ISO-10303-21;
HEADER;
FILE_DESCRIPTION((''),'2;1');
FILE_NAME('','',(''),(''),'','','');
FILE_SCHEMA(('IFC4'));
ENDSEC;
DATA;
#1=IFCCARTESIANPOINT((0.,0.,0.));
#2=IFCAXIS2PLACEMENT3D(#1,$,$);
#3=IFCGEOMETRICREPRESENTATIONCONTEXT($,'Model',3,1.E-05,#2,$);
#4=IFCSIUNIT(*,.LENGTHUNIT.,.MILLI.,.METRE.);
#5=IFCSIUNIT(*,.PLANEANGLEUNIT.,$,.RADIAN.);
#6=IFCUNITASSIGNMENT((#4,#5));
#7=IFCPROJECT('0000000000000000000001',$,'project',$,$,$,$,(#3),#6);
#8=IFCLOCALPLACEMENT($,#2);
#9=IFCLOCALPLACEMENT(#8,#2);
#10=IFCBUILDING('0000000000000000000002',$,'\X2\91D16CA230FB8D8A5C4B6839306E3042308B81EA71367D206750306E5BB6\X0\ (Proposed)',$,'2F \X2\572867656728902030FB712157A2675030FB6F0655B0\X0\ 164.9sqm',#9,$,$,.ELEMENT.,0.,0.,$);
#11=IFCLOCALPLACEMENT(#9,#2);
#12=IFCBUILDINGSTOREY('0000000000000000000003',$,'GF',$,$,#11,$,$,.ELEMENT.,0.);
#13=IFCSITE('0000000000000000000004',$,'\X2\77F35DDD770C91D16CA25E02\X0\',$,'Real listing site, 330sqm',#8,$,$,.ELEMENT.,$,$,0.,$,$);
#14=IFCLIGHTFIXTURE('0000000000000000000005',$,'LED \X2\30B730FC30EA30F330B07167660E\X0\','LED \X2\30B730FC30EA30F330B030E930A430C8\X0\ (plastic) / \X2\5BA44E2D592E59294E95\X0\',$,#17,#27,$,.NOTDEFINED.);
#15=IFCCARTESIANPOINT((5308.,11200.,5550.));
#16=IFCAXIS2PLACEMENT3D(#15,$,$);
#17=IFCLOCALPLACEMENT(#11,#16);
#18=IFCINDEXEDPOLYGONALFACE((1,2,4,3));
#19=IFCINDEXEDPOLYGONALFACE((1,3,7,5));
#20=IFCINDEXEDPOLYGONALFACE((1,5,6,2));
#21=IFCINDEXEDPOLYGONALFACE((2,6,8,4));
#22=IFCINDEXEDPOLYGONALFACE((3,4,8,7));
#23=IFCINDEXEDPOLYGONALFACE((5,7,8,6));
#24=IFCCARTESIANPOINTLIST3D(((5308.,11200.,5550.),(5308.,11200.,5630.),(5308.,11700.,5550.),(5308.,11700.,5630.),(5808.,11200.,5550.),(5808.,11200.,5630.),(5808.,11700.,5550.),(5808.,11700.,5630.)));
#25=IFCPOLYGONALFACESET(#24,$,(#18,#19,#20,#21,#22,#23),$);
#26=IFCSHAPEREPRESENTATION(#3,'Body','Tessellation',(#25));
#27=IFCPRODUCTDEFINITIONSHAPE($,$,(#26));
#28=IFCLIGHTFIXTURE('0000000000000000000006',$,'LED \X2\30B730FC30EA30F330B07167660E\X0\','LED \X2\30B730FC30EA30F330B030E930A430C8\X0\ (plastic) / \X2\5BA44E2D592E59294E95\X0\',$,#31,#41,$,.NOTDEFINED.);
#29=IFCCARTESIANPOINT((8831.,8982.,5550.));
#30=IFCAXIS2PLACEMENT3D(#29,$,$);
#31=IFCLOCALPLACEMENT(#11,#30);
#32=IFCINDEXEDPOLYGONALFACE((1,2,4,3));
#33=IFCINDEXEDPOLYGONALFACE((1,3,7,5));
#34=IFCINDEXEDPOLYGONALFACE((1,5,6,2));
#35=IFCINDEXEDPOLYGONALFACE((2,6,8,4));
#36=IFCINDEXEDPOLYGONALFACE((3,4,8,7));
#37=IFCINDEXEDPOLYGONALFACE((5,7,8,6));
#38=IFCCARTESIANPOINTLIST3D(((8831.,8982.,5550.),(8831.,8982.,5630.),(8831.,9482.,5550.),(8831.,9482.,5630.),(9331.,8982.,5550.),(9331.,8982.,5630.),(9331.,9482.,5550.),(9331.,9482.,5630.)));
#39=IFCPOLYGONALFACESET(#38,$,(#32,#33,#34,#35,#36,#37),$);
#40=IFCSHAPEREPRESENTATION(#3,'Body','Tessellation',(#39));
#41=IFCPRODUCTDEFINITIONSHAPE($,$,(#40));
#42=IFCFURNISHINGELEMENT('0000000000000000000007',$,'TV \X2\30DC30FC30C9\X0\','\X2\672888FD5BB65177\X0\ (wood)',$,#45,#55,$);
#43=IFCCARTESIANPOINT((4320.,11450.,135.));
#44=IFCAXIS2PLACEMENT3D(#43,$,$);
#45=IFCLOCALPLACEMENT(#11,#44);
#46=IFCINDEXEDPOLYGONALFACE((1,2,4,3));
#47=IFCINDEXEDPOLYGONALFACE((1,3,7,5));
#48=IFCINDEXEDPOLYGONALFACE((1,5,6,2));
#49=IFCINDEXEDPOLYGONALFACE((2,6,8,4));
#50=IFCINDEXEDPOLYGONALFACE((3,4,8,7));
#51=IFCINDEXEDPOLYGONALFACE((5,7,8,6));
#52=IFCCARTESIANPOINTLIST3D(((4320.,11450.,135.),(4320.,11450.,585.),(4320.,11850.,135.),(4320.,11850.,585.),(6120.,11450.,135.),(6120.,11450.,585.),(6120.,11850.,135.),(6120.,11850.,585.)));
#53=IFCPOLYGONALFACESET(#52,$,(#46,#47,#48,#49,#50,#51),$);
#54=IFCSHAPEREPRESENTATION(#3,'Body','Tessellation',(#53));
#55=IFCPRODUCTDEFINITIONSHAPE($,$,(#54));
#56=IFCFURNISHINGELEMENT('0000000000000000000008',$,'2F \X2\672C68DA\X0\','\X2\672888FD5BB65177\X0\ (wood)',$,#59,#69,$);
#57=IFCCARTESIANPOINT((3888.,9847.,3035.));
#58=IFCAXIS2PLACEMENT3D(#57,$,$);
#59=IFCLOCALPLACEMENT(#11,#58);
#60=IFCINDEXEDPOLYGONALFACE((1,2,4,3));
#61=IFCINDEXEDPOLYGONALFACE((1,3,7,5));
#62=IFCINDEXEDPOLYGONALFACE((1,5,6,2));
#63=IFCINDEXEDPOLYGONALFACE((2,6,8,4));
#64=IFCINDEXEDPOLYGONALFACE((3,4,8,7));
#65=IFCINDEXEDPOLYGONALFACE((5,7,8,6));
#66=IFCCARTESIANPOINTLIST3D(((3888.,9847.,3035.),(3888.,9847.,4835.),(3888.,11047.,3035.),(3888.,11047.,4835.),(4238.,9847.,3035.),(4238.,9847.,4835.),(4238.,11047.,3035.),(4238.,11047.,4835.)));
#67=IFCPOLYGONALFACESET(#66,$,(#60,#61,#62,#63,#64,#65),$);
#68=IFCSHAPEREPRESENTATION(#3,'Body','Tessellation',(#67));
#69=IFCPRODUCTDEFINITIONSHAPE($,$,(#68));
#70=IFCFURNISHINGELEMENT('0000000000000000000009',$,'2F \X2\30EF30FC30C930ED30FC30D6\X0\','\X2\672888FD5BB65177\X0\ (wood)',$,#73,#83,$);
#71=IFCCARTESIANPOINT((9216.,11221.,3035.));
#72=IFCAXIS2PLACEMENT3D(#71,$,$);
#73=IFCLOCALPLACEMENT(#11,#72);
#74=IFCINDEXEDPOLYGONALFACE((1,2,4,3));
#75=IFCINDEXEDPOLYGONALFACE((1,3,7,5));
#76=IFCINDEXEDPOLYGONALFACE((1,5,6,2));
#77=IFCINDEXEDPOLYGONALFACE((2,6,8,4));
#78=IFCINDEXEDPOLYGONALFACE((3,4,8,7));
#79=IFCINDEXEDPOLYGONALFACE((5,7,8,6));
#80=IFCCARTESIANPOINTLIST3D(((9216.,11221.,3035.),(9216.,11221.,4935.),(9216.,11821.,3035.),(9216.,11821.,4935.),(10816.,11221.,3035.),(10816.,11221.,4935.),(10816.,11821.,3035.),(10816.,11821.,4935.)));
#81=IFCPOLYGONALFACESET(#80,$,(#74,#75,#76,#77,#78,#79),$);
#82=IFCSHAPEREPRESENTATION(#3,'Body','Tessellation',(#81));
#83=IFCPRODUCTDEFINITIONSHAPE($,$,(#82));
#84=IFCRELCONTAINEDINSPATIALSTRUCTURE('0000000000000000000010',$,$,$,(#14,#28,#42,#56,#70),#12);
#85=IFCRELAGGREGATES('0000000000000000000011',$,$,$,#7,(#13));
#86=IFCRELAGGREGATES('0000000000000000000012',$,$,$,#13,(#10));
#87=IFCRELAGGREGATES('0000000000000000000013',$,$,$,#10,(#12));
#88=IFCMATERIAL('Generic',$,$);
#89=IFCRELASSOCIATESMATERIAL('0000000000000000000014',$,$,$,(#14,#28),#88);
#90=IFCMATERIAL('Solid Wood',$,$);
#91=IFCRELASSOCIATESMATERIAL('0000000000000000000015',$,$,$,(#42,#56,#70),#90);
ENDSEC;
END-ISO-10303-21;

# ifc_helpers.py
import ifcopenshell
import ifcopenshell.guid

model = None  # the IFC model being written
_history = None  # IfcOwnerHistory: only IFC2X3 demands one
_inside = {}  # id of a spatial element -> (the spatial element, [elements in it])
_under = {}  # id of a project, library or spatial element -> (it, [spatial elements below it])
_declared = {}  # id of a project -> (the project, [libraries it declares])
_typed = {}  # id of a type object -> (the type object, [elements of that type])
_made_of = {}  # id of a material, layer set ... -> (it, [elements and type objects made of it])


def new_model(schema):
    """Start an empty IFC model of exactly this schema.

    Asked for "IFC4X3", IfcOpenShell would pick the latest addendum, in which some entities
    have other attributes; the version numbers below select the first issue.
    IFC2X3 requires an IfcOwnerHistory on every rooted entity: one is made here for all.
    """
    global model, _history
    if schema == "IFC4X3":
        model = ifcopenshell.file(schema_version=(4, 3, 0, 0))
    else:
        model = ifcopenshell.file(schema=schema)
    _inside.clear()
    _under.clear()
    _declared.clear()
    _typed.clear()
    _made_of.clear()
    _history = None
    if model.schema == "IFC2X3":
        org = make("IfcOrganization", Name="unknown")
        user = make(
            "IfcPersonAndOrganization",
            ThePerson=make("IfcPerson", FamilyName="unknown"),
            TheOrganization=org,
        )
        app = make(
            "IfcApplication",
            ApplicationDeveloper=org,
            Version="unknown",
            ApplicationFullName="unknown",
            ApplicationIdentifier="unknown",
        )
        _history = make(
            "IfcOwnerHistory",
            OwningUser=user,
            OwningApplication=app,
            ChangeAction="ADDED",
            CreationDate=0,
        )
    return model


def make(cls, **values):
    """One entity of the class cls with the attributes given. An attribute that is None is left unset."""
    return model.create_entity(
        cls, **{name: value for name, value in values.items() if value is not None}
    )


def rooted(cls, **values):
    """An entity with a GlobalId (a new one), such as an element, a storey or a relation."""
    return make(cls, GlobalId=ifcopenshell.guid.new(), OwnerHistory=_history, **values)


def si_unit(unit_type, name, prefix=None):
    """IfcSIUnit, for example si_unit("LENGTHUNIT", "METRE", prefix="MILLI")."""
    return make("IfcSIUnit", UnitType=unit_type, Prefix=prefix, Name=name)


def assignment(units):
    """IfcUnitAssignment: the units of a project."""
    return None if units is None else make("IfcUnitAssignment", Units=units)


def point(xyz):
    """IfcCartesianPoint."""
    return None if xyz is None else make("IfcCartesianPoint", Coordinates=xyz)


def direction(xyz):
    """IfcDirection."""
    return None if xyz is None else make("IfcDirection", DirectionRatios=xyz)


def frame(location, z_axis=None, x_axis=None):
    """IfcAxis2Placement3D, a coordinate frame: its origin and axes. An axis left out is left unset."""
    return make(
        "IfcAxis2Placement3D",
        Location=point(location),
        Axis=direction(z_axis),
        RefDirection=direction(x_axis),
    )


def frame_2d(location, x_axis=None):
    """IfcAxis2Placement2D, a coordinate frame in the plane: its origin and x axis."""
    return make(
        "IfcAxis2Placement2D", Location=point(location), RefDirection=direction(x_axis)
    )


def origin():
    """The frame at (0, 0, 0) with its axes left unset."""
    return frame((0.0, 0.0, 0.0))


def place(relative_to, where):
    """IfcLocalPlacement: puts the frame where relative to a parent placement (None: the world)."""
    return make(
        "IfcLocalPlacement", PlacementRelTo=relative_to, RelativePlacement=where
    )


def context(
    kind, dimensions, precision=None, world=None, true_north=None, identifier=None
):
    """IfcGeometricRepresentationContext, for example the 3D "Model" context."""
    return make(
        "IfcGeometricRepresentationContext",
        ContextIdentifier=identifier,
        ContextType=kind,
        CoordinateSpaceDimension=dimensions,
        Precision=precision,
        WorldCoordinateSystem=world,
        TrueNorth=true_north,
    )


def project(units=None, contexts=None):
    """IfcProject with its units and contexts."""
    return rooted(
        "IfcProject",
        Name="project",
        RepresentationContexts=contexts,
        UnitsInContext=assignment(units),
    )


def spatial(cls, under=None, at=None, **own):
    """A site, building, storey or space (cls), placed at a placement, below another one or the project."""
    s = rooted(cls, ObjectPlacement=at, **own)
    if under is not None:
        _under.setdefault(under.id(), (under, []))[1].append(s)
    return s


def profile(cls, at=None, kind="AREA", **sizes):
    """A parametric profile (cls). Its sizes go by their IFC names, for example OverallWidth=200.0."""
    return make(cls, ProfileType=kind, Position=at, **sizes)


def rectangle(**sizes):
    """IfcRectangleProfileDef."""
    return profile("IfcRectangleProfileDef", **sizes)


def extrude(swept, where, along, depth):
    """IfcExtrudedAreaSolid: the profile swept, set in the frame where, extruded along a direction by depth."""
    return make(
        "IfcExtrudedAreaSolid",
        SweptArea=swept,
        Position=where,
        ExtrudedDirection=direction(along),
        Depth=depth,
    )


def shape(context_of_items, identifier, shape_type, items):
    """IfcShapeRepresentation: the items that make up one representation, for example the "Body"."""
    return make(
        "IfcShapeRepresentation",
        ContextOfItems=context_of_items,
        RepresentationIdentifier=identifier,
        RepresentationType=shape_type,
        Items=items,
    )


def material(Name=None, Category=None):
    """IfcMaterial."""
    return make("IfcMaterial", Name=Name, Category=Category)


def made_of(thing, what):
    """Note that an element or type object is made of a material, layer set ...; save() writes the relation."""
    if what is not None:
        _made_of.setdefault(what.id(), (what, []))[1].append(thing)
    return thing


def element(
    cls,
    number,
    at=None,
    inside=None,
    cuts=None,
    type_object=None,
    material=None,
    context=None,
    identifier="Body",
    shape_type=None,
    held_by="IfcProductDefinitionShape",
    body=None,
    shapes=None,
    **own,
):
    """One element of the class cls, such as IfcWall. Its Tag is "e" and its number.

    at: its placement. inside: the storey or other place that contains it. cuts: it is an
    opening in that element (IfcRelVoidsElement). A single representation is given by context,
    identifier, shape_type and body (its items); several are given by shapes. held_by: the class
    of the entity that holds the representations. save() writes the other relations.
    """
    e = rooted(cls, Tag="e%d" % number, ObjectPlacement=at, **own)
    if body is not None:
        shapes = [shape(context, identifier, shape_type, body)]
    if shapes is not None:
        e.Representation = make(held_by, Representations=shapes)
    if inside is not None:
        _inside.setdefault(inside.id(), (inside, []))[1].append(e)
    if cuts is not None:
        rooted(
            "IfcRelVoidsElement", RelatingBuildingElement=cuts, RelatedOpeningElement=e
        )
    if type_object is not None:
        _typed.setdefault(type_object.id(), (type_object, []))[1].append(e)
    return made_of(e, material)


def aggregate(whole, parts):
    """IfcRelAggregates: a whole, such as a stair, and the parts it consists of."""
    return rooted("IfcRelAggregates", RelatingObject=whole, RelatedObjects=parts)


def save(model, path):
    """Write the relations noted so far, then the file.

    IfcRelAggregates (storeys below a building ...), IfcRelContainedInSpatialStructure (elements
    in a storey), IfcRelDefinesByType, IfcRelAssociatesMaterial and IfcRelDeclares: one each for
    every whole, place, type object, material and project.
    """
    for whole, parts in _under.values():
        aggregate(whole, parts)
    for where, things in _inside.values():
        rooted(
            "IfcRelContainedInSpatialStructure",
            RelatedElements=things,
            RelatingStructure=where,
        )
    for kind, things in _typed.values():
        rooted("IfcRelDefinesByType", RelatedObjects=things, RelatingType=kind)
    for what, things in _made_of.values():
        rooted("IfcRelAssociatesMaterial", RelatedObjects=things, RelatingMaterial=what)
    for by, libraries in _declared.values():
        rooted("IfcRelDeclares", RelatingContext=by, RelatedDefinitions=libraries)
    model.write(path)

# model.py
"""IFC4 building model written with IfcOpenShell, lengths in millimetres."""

from ifc_helpers import new_model, si_unit, frame, frame_2d, origin, place, context, project, spatial, rectangle, extrude, material, element, save


model = new_model("IFC4")

# Units and contexts
model_context = context("Model", 3, precision=1e-05, world=origin())
ifc_project = project(units=[si_unit("LENGTHUNIT", "METRE", prefix="MILLI"), si_unit("PLANEANGLEUNIT", "RADIAN")], contexts=[model_context])

# Site, building, storey
site_placement = place(None, origin())
site = spatial("IfcSite", under=ifc_project, at=site_placement, Name="石川県金沢市", ObjectType="Real listing site, 330sqm", CompositionType="ELEMENT", RefElevation=0.0)
building_placement = place(site_placement, origin())
building = spatial("IfcBuilding", under=site, at=building_placement, Name="金沢・越屋根のある自然素材の家 (Proposed)", ObjectType="2F 在来木造・無垢材・漆喰 164.9sqm", CompositionType="ELEMENT", ElevationOfRefHeight=0.0, ElevationOfTerrain=0.0)
storey_placement = place(building_placement, origin())
storey = spatial("IfcBuildingStorey", under=building, at=storey_placement, Name="GF", CompositionType="ELEMENT", Elevation=0.0)

# Shared definitions
ifc_material_1 = material(Name="Solid Wood")

# Shared definitions
ifc_material_2 = material(Name="Generic")

# Light fixtures
light_fixture_1_placement = place(storey_placement, frame((5308.0, 11200.0, 5550.0)))
element("IfcLightFixture", 1, at=light_fixture_1_placement, inside=storey, material=ifc_material_2, Name="LED シーリング照明", Description="LED シーリングライト (plastic) / 室中央天井", PredefinedType="NOTDEFINED", context=model_context, shape_type="SweptSolid", body=[
    extrude(rectangle(XDim=500.0, YDim=500.0, at=frame_2d((250.0, 250.0))), frame((5308.0, 11200.0, 5550.0)), (0.0, 0.0, 1.0), 80.0),
])
light_fixture_2_placement = place(storey_placement, frame((8831.0, 8982.0, 5550.0)))
element("IfcLightFixture", 2, at=light_fixture_2_placement, inside=storey, material=ifc_material_2, Name="LED シーリング照明", Description="LED シーリングライト (plastic) / 室中央天井", PredefinedType="NOTDEFINED", context=model_context, shape_type="SweptSolid", body=[
    extrude(rectangle(XDim=500.0, YDim=500.0, at=frame_2d((250.0, 250.0))), frame((8831.0, 8982.0, 5550.0)), (0.0, 0.0, 1.0), 80.0),
])

# Furnishing elements
furnishing_1_placement = place(storey_placement, frame((4320.0, 11450.0, 135.0)))
element("IfcFurnishingElement", 3, at=furnishing_1_placement, inside=storey, material=ifc_material_1, Name="TV ボード", Description="木製家具 (wood)", context=model_context, shape_type="SweptSolid", body=[
    extrude(rectangle(XDim=1800.0, YDim=400.0, at=frame_2d((900.0, 200.0))), frame((4320.0, 11450.0, 135.0)), (0.0, 0.0, 1.0), 450.0),
])
furnishing_2_placement = place(storey_placement, frame((3888.0, 9847.0, 3035.0)))
element("IfcFurnishingElement", 4, at=furnishing_2_placement, inside=storey, material=ifc_material_1, Name="2F 本棚", Description="木製家具 (wood)", context=model_context, shape_type="SweptSolid", body=[
    extrude(rectangle(XDim=350.0, YDim=1200.0, at=frame_2d((175.0, 600.0))), frame((3888.0, 9847.0, 3035.0)), (0.0, 0.0, 1.0), 1800.0),
])
furnishing_3_placement = place(storey_placement, frame((9216.0, 11221.0, 3035.0)))
element("IfcFurnishingElement", 5, at=furnishing_3_placement, inside=storey, material=ifc_material_1, Name="2F ワードローブ", Description="木製家具 (wood)", context=model_context, shape_type="SweptSolid", body=[
    extrude(rectangle(XDim=1600.0, YDim=600.0, at=frame_2d((800.0, 300.0))), frame((9216.0, 11221.0, 3035.0)), (0.0, 0.0, 1.0), 1900.0),
])

save(model, "model.ifc")
